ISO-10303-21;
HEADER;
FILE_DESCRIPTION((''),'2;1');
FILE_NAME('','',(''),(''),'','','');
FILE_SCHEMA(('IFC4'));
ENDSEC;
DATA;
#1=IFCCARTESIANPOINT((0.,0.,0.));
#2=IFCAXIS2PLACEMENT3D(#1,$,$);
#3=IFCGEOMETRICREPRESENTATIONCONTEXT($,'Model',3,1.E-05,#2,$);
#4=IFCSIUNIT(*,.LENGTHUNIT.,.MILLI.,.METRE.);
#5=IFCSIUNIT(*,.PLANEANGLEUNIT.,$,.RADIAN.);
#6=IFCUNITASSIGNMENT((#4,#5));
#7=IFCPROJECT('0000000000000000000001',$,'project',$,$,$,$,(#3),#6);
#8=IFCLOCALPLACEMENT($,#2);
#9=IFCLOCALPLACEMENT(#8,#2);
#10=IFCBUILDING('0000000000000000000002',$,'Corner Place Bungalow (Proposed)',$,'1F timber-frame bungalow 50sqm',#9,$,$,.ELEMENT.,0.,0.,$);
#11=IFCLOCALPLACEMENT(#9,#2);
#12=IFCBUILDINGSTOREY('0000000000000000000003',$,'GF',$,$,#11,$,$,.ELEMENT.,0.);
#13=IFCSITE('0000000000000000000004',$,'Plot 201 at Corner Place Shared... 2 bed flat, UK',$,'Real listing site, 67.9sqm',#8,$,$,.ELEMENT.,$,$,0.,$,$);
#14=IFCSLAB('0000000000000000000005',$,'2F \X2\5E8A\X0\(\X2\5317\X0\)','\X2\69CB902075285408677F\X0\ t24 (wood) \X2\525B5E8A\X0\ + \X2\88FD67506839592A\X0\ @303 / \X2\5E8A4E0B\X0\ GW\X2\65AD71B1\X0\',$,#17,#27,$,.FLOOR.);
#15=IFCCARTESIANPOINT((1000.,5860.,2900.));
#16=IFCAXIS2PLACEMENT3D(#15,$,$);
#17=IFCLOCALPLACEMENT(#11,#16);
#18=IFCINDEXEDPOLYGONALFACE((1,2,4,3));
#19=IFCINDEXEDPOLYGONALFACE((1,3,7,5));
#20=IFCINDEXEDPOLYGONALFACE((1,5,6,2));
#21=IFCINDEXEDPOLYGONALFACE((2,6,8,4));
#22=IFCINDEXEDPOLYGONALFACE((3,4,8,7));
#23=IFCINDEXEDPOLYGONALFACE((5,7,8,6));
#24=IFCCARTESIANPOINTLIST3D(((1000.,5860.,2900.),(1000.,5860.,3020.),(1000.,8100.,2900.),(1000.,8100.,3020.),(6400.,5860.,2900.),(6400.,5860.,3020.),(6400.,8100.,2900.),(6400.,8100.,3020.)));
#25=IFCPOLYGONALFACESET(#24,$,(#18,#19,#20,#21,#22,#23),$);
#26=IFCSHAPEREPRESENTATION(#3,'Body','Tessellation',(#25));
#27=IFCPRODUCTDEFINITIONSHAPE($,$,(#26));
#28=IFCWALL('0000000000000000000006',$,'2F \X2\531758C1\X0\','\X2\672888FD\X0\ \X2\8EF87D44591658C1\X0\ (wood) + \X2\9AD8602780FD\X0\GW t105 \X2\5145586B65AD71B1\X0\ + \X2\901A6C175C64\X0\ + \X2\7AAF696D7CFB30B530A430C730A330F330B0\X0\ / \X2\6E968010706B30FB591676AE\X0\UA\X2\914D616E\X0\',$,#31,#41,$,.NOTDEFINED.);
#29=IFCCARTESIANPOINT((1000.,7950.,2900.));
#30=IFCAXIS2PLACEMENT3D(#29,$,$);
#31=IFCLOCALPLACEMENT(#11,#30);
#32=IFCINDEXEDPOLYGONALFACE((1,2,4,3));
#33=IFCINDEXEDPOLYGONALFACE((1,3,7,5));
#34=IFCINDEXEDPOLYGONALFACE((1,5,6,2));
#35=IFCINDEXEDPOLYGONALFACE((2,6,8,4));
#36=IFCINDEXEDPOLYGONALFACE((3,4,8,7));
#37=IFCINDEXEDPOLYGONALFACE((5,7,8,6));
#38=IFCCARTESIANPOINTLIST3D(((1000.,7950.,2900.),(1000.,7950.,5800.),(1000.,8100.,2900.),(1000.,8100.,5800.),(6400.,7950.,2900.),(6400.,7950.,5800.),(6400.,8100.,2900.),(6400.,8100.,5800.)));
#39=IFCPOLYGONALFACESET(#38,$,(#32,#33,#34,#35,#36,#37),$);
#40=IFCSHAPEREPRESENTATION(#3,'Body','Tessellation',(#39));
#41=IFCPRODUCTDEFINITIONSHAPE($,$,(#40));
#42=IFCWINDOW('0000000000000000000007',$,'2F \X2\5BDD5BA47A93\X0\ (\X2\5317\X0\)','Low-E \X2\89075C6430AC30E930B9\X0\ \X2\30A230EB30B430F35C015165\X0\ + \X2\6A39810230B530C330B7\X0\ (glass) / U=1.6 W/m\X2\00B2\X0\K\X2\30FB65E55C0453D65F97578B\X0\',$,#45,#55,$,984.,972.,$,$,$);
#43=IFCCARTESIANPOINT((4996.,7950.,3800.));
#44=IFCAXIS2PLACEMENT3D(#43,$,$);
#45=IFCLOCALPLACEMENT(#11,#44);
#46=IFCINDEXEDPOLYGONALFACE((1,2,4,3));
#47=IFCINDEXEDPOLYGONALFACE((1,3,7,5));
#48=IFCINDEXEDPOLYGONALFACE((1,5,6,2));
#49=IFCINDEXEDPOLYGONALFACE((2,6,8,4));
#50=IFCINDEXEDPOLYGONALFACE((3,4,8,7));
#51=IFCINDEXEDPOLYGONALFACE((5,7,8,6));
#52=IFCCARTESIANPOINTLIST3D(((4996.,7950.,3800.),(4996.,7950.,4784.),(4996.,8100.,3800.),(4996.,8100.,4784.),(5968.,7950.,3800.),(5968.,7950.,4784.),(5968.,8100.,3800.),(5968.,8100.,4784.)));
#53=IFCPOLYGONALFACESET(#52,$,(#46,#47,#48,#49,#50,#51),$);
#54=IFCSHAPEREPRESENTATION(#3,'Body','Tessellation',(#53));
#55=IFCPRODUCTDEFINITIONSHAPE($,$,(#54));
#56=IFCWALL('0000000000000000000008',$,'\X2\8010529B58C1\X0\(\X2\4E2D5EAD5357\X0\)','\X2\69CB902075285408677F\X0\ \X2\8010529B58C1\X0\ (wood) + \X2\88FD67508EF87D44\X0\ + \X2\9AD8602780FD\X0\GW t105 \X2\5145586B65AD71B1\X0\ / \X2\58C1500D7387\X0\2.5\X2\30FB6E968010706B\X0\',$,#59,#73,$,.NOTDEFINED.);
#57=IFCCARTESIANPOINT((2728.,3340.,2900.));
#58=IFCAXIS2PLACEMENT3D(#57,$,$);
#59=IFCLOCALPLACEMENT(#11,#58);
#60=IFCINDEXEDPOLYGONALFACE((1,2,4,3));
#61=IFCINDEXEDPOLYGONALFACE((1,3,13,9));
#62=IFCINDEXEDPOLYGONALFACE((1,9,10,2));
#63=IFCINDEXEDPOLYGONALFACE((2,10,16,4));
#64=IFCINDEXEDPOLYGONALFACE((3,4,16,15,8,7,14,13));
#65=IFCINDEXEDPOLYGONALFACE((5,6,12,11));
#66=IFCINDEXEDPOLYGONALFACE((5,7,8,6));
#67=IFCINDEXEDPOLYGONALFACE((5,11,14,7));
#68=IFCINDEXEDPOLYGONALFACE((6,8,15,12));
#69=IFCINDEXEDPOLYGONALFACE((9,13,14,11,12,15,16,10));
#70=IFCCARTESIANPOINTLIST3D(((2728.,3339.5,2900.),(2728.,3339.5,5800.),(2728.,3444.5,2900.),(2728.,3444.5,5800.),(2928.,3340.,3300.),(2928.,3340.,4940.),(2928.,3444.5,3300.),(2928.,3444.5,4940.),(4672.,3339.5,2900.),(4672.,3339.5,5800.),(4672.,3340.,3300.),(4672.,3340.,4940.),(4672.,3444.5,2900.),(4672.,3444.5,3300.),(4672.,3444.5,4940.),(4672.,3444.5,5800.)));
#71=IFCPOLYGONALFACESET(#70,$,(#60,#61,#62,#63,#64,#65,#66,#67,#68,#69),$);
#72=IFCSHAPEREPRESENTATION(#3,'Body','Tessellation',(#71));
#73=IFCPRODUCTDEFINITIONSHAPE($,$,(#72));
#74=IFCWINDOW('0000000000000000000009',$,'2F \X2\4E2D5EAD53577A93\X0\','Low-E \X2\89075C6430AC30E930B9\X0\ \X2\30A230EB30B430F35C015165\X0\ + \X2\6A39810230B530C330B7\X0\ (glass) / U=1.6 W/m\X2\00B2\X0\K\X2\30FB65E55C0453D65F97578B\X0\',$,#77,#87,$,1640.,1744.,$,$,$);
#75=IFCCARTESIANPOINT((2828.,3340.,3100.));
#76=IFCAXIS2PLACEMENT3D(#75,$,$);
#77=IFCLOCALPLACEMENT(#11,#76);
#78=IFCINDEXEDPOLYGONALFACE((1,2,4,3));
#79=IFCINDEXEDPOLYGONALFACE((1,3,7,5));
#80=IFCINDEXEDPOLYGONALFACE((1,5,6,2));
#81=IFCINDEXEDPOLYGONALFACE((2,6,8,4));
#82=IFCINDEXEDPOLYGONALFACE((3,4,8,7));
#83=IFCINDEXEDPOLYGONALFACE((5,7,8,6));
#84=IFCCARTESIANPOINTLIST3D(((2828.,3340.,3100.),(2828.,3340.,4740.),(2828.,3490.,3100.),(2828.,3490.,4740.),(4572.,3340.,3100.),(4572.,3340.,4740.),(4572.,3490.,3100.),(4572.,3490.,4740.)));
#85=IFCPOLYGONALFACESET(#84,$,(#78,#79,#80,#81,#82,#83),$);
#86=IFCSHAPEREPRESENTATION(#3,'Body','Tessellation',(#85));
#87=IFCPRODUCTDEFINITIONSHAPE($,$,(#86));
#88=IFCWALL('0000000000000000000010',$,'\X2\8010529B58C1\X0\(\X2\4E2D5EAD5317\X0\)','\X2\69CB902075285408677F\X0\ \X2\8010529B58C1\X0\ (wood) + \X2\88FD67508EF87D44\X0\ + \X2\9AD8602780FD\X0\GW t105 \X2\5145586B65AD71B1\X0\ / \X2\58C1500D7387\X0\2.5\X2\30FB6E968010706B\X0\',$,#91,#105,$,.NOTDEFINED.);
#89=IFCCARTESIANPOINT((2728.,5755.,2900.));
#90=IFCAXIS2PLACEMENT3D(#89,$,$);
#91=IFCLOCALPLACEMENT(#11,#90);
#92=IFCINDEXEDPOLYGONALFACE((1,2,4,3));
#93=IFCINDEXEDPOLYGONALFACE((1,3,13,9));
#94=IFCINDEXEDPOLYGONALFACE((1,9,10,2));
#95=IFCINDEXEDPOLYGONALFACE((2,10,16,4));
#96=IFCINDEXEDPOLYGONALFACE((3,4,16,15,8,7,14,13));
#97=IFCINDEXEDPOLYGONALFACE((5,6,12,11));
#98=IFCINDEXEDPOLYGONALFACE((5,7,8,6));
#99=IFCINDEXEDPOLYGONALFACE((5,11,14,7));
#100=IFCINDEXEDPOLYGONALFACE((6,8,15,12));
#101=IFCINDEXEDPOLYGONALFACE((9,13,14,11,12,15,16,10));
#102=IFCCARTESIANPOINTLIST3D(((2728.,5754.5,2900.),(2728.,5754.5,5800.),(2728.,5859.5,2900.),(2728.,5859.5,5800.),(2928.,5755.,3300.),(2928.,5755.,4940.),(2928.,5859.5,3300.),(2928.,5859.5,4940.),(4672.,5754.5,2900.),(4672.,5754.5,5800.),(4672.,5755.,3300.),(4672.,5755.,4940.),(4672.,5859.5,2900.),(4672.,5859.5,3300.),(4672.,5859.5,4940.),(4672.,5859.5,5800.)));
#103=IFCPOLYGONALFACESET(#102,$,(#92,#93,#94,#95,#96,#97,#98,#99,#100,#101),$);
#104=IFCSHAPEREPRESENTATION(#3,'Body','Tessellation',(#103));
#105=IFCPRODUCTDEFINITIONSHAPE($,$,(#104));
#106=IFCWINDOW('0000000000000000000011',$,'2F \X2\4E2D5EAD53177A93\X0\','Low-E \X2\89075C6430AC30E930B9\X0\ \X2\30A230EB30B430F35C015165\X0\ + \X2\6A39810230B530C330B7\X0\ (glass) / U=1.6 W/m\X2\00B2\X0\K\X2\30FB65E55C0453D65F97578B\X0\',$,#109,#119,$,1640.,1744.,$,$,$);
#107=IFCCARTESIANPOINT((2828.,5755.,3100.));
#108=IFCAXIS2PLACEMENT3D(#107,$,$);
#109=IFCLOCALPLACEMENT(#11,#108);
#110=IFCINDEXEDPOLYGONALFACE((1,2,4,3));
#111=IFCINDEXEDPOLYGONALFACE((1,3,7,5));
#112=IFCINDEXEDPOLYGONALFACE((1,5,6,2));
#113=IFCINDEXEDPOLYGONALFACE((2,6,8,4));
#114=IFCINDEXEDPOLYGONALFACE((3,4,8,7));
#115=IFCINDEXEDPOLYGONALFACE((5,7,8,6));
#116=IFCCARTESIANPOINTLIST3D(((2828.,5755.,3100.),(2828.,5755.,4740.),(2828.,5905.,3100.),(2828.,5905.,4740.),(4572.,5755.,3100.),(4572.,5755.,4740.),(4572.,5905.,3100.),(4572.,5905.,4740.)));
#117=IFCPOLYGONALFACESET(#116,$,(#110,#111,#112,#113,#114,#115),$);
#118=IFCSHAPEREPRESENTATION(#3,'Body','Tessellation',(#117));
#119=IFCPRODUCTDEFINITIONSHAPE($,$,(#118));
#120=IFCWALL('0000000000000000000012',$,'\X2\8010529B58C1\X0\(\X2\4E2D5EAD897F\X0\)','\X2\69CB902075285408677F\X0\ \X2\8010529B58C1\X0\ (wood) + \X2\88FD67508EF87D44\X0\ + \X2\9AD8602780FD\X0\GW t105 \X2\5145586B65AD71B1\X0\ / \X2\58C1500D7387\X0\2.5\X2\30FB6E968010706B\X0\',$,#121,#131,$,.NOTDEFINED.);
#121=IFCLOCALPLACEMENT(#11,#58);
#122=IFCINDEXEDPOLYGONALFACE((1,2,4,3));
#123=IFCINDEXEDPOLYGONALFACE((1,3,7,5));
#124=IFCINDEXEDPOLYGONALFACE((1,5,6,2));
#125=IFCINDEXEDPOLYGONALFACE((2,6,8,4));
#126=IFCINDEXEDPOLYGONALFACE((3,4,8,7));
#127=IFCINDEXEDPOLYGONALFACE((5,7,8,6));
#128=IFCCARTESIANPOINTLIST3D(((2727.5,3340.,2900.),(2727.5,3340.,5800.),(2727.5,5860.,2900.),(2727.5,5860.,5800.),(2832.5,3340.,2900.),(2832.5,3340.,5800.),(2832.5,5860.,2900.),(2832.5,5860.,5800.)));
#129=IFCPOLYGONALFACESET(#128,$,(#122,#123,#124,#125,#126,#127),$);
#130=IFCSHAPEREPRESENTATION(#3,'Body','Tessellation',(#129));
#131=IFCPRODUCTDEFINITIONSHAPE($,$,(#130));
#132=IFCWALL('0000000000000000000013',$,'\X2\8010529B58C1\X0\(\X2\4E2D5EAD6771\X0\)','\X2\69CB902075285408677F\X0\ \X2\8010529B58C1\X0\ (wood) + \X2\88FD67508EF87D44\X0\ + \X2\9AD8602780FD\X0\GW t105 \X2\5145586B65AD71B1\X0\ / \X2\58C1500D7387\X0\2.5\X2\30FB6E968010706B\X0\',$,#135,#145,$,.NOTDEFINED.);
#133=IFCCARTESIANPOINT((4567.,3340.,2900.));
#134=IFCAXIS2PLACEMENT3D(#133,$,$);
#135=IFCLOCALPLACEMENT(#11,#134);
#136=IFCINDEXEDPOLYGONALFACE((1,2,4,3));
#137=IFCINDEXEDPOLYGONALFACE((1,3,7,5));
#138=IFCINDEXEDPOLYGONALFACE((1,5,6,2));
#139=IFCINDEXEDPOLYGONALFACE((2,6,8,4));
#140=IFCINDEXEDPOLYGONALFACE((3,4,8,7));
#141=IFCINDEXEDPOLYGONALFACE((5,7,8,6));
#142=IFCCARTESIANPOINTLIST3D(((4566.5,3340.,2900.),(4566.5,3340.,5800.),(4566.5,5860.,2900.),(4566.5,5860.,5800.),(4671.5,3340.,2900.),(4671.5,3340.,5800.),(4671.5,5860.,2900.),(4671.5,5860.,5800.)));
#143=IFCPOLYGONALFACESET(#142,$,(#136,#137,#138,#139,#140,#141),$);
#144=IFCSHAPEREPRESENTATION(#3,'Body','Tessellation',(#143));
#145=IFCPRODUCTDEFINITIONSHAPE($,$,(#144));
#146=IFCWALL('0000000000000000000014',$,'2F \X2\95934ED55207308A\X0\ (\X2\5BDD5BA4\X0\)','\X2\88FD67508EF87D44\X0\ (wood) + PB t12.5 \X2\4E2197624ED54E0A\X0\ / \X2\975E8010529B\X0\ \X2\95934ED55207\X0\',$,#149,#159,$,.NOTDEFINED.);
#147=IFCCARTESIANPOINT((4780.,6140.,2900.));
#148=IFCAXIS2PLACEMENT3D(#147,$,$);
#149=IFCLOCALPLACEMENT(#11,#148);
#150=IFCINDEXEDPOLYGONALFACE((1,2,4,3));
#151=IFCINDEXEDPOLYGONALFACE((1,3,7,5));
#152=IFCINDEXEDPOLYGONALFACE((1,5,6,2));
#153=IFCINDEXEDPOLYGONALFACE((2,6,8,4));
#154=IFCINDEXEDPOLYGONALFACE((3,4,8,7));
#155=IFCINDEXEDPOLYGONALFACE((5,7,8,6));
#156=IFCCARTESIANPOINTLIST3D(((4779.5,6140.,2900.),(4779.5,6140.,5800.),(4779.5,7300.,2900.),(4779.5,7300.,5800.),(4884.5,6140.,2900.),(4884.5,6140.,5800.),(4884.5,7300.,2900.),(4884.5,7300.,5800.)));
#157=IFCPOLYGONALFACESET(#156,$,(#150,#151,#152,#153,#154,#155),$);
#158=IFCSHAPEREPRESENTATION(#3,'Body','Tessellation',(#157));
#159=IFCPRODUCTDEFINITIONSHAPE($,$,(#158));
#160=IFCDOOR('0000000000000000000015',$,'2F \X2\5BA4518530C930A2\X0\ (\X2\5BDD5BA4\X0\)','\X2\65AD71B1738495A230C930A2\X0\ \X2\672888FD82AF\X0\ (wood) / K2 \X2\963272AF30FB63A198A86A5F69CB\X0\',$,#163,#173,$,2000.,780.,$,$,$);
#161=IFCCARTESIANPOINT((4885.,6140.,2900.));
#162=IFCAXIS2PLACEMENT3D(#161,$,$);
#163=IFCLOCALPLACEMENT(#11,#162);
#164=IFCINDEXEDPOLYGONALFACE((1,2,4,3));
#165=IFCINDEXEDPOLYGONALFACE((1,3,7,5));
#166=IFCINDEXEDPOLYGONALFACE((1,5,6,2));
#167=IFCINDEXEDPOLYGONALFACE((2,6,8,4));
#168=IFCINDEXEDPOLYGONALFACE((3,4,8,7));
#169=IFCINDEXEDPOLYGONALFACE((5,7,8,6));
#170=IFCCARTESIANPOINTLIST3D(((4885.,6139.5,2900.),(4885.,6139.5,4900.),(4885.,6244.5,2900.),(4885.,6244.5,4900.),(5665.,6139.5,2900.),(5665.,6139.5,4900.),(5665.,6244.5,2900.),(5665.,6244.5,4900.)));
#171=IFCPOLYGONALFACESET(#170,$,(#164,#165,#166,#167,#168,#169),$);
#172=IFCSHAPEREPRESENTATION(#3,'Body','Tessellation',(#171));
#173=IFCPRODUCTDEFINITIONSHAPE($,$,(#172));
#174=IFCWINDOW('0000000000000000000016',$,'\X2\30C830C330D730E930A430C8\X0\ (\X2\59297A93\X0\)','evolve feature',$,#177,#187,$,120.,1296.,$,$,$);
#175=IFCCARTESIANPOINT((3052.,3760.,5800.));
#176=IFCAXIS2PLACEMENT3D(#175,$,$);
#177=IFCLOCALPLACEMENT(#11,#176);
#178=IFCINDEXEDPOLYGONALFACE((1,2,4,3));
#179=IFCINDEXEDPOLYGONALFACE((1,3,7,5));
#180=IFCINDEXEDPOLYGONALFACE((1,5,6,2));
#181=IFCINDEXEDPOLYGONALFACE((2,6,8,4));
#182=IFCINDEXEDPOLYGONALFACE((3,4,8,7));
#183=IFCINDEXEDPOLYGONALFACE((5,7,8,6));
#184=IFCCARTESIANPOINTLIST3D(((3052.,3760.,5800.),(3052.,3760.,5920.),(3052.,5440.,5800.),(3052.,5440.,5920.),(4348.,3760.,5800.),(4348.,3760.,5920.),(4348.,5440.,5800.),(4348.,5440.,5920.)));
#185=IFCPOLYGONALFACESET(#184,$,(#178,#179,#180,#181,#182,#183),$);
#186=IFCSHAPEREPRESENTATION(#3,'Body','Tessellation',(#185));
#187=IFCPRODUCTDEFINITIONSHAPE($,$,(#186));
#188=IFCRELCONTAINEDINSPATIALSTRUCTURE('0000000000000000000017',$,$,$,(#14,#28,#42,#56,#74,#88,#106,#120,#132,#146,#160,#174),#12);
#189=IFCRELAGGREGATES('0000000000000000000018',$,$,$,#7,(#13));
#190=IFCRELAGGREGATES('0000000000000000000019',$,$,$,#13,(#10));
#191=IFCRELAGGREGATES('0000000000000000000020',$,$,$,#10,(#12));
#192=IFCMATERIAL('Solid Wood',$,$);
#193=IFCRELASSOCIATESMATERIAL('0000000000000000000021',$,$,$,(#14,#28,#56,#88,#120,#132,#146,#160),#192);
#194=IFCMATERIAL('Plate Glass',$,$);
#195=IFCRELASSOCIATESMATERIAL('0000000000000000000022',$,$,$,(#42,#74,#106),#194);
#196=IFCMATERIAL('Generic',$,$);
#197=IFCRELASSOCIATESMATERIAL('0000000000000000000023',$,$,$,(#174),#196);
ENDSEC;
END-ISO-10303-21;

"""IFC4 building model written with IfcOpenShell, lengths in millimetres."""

from ifc_helpers import new_model, si_unit, frame, frame_2d, origin, place, context, project, spatial, rectangle, extrude, material, element, fill, save


model = new_model("IFC4")

# Units and contexts
model_context = context("Model", 3, precision=1e-05, world=origin())
ifc_project = project(units=[si_unit("LENGTHUNIT", "METRE", prefix="MILLI"), si_unit("PLANEANGLEUNIT", "RADIAN")], contexts=[model_context])

# Site, building, storey
site_placement = place(None, origin())
site = spatial("IfcSite", under=ifc_project, at=site_placement, Name="Plot 201 at Corner Place Shared... 2 bed flat, UK", ObjectType="Real listing site, 67.9sqm", CompositionType="ELEMENT", RefElevation=0.0)
building_placement = place(site_placement, origin())
building = spatial("IfcBuilding", under=site, at=building_placement, Name="Corner Place Bungalow (Proposed)", ObjectType="1F timber-frame bungalow 50sqm", CompositionType="ELEMENT", ElevationOfRefHeight=0.0, ElevationOfTerrain=0.0)
storey_placement = place(building_placement, origin())
storey = spatial("IfcBuildingStorey", under=building, at=storey_placement, Name="GF", CompositionType="ELEMENT", Elevation=0.0)

# Slab
ifc_material_1 = material(Name="Solid Wood")
slab_placement = place(storey_placement, frame((1000.0, 5860.0, 2900.0)))
element("IfcSlab", 1, at=slab_placement, inside=storey, material=ifc_material_1, Name="2F 床(北)", Description="構造用合板 t24 (wood) 剛床 + 製材根太 @303 / 床下 GW断熱", PredefinedType="FLOOR", context=model_context, shape_type="SweptSolid", body=[
    extrude(rectangle(XDim=5400.0, YDim=2240.0, at=frame_2d((2700.0, 1120.0))), frame((1000.0, 5860.0, 2900.0)), (0.0, 0.0, 1.0), 120.0),
])

# Walls, openings, windows
wall_1_placement = place(storey_placement, frame((1000.0, 7950.0, 2900.0)))
wall_1 = element("IfcWall", 2, at=wall_1_placement, inside=storey, material=ifc_material_1, Name="2F 北壁", Description="木製 軸組外壁 (wood) + 高性能GW t105 充填断熱 + 通気層 + 窯業系サイディング / 準耐火・外皮UA配慮", PredefinedType="NOTDEFINED", context=model_context, shape_type="SweptSolid", body=[
    extrude(rectangle(XDim=5400.0, YDim=150.0, at=frame_2d((2700.0, 75.0))), frame((1000.0, 7950.0, 2900.0)), (0.0, 0.0, 1.0), 2900.0),
])
opening_1_placement = place(storey_placement, frame((4996.0, 7950.0, 3800.0)))
opening_1 = element("IfcOpeningElement", 3, at=opening_1_placement, cuts=wall_1, PredefinedType="NOTDEFINED", context=model_context, shape_type="SweptSolid", body=[
    extrude(rectangle(XDim=972.0, YDim=150.0, at=frame_2d((486.0, 75.0))), frame((4996.0, 7950.0, 3800.0)), (0.0, 0.0, 1.0), 984.0),
])
ifc_material_2 = material(Name="Plate Glass")
window_1_placement = place(storey_placement, frame((4996.0, 7950.0, 3800.0)))
window_1 = element("IfcWindow", 4, at=window_1_placement, inside=storey, material=ifc_material_2, Name="2F 寝室窓 (北)", Description="Low-E 複層ガラス アルゴン封入 + 樹脂サッシ (glass) / U=1.6 W/m²K・日射取得型", OverallHeight=984.0, OverallWidth=972.0, context=model_context, shape_type="SweptSolid", body=[
    extrude(rectangle(XDim=972.0, YDim=150.0, at=frame_2d((486.0, 75.0))), frame((4996.0, 7950.0, 3800.0)), (0.0, 0.0, 1.0), 984.0),
])
fill(opening_1, window_1)
wall_2_placement = place(storey_placement, frame((2728.0, 3340.0, 2900.0)))
wall_2 = element("IfcWall", 5, at=wall_2_placement, inside=storey, material=ifc_material_1, Name="耐力壁(中庭南)", Description="構造用合板 耐力壁 (wood) + 製材軸組 + 高性能GW t105 充填断熱 / 壁倍率2.5・準耐火", PredefinedType="NOTDEFINED", context=model_context, shape_type="SweptSolid", body=[
    extrude(rectangle(XDim=1944.0, YDim=105.0, at=frame_2d((972.0, 52.0))), frame((2728.0, 3340.0, 2900.0)), (0.0, 0.0, 1.0), 2900.0),
])
opening_2_placement = place(storey_placement, frame((2828.0, 3340.0, 3100.0)))
opening_2 = element("IfcOpeningElement", 6, at=opening_2_placement, cuts=wall_2, PredefinedType="NOTDEFINED", context=model_context, shape_type="SweptSolid", body=[
    extrude(rectangle(XDim=1744.0, YDim=150.0, at=frame_2d((872.0, 75.0))), frame((2828.0, 3340.0, 3100.0)), (0.0, 0.0, 1.0), 1640.0),
])
window_2_placement = place(storey_placement, frame((2828.0, 3340.0, 3100.0)))
window_2 = element("IfcWindow", 7, at=window_2_placement, inside=storey, material=ifc_material_2, Name="2F 中庭南窓", Description="Low-E 複層ガラス アルゴン封入 + 樹脂サッシ (glass) / U=1.6 W/m²K・日射取得型", OverallHeight=1640.0, OverallWidth=1744.0, context=model_context, shape_type="SweptSolid", body=[
    extrude(rectangle(XDim=1744.0, YDim=150.0, at=frame_2d((872.0, 75.0))), frame((2828.0, 3340.0, 3100.0)), (0.0, 0.0, 1.0), 1640.0),
])
fill(opening_2, window_2)
wall_3_placement = place(storey_placement, frame((2728.0, 5755.0, 2900.0)))
wall_3 = element("IfcWall", 8, at=wall_3_placement, inside=storey, material=ifc_material_1, Name="耐力壁(中庭北)", Description="構造用合板 耐力壁 (wood) + 製材軸組 + 高性能GW t105 充填断熱 / 壁倍率2.5・準耐火", PredefinedType="NOTDEFINED", context=model_context, shape_type="SweptSolid", body=[
    extrude(rectangle(XDim=1944.0, YDim=105.0, at=frame_2d((972.0, 52.0))), frame((2728.0, 5755.0, 2900.0)), (0.0, 0.0, 1.0), 2900.0),
])
opening_3_placement = place(storey_placement, frame((2828.0, 5755.0, 3100.0)))
opening_3 = element("IfcOpeningElement", 9, at=opening_3_placement, cuts=wall_3, PredefinedType="NOTDEFINED", context=model_context, shape_type="SweptSolid", body=[
    extrude(rectangle(XDim=1744.0, YDim=150.0, at=frame_2d((872.0, 75.0))), frame((2828.0, 5755.0, 3100.0)), (0.0, 0.0, 1.0), 1640.0),
])
window_3_placement = place(storey_placement, frame((2828.0, 5755.0, 3100.0)))
window_3 = element("IfcWindow", 10, at=window_3_placement, inside=storey, material=ifc_material_2, Name="2F 中庭北窓", Description="Low-E 複層ガラス アルゴン封入 + 樹脂サッシ (glass) / U=1.6 W/m²K・日射取得型", OverallHeight=1640.0, OverallWidth=1744.0, context=model_context, shape_type="SweptSolid", body=[
    extrude(rectangle(XDim=1744.0, YDim=150.0, at=frame_2d((872.0, 75.0))), frame((2828.0, 5755.0, 3100.0)), (0.0, 0.0, 1.0), 1640.0),
])
fill(opening_3, window_3)

# Walls
wall_4_placement = place(storey_placement, frame((2728.0, 3340.0, 2900.0)))
element("IfcWall", 11, at=wall_4_placement, inside=storey, material=ifc_material_1, Name="耐力壁(中庭西)", Description="構造用合板 耐力壁 (wood) + 製材軸組 + 高性能GW t105 充填断熱 / 壁倍率2.5・準耐火", PredefinedType="NOTDEFINED", context=model_context, shape_type="SweptSolid", body=[
    extrude(rectangle(XDim=105.0, YDim=2520.0, at=frame_2d((52.0, 1260.0))), frame((2728.0, 3340.0, 2900.0)), (0.0, 0.0, 1.0), 2900.0),
])
wall_5_placement = place(storey_placement, frame((4567.0, 3340.0, 2900.0)))
element("IfcWall", 12, at=wall_5_placement, inside=storey, material=ifc_material_1, Name="耐力壁(中庭東)", Description="構造用合板 耐力壁 (wood) + 製材軸組 + 高性能GW t105 充填断熱 / 壁倍率2.5・準耐火", PredefinedType="NOTDEFINED", context=model_context, shape_type="SweptSolid", body=[
    extrude(rectangle(XDim=105.0, YDim=2520.0, at=frame_2d((52.0, 1260.0))), frame((4567.0, 3340.0, 2900.0)), (0.0, 0.0, 1.0), 2900.0),
])
wall_6_placement = place(storey_placement, frame((4780.0, 6140.0, 2900.0)))
element("IfcWall", 13, at=wall_6_placement, inside=storey, material=ifc_material_1, Name="2F 間仕切り (寝室)", Description="製材軸組 (wood) + PB t12.5 両面仕上 / 非耐力 間仕切", PredefinedType="NOTDEFINED", context=model_context, shape_type="SweptSolid", body=[
    extrude(rectangle(XDim=105.0, YDim=1160.0, at=frame_2d((52.0, 580.0))), frame((4780.0, 6140.0, 2900.0)), (0.0, 0.0, 1.0), 2900.0),
])

# Door
door_placement = place(storey_placement, frame((4885.0, 6140.0, 2900.0)))
element("IfcDoor", 14, at=door_placement, inside=storey, material=ifc_material_1, Name="2F 室内ドア (寝室)", Description="断熱玄関ドア 木製芯 (wood) / K2 防犯・採風機構", OverallHeight=2000.0, OverallWidth=780.0, context=model_context, shape_type="SweptSolid", body=[
    extrude(rectangle(XDim=780.0, YDim=105.0, at=frame_2d((390.0, 52.0))), frame((4885.0, 6140.0, 2900.0)), (0.0, 0.0, 1.0), 2000.0),
])

# Window
ifc_material_3 = material(Name="Generic")
window_4_placement = place(storey_placement, frame((3052.0, 3760.0, 5800.0)))
element("IfcWindow", 15, at=window_4_placement, inside=storey, material=ifc_material_3, Name="トップライト (天窓)", Description="evolve feature", OverallHeight=120.0, OverallWidth=1296.0, context=model_context, shape_type="SweptSolid", body=[
    extrude(rectangle(XDim=1296.0, YDim=1680.0, at=frame_2d((648.0, 840.0))), frame((3052.0, 3760.0, 5800.0)), (0.0, 0.0, 1.0), 120.0),
])

save(model, "model.ifc")
